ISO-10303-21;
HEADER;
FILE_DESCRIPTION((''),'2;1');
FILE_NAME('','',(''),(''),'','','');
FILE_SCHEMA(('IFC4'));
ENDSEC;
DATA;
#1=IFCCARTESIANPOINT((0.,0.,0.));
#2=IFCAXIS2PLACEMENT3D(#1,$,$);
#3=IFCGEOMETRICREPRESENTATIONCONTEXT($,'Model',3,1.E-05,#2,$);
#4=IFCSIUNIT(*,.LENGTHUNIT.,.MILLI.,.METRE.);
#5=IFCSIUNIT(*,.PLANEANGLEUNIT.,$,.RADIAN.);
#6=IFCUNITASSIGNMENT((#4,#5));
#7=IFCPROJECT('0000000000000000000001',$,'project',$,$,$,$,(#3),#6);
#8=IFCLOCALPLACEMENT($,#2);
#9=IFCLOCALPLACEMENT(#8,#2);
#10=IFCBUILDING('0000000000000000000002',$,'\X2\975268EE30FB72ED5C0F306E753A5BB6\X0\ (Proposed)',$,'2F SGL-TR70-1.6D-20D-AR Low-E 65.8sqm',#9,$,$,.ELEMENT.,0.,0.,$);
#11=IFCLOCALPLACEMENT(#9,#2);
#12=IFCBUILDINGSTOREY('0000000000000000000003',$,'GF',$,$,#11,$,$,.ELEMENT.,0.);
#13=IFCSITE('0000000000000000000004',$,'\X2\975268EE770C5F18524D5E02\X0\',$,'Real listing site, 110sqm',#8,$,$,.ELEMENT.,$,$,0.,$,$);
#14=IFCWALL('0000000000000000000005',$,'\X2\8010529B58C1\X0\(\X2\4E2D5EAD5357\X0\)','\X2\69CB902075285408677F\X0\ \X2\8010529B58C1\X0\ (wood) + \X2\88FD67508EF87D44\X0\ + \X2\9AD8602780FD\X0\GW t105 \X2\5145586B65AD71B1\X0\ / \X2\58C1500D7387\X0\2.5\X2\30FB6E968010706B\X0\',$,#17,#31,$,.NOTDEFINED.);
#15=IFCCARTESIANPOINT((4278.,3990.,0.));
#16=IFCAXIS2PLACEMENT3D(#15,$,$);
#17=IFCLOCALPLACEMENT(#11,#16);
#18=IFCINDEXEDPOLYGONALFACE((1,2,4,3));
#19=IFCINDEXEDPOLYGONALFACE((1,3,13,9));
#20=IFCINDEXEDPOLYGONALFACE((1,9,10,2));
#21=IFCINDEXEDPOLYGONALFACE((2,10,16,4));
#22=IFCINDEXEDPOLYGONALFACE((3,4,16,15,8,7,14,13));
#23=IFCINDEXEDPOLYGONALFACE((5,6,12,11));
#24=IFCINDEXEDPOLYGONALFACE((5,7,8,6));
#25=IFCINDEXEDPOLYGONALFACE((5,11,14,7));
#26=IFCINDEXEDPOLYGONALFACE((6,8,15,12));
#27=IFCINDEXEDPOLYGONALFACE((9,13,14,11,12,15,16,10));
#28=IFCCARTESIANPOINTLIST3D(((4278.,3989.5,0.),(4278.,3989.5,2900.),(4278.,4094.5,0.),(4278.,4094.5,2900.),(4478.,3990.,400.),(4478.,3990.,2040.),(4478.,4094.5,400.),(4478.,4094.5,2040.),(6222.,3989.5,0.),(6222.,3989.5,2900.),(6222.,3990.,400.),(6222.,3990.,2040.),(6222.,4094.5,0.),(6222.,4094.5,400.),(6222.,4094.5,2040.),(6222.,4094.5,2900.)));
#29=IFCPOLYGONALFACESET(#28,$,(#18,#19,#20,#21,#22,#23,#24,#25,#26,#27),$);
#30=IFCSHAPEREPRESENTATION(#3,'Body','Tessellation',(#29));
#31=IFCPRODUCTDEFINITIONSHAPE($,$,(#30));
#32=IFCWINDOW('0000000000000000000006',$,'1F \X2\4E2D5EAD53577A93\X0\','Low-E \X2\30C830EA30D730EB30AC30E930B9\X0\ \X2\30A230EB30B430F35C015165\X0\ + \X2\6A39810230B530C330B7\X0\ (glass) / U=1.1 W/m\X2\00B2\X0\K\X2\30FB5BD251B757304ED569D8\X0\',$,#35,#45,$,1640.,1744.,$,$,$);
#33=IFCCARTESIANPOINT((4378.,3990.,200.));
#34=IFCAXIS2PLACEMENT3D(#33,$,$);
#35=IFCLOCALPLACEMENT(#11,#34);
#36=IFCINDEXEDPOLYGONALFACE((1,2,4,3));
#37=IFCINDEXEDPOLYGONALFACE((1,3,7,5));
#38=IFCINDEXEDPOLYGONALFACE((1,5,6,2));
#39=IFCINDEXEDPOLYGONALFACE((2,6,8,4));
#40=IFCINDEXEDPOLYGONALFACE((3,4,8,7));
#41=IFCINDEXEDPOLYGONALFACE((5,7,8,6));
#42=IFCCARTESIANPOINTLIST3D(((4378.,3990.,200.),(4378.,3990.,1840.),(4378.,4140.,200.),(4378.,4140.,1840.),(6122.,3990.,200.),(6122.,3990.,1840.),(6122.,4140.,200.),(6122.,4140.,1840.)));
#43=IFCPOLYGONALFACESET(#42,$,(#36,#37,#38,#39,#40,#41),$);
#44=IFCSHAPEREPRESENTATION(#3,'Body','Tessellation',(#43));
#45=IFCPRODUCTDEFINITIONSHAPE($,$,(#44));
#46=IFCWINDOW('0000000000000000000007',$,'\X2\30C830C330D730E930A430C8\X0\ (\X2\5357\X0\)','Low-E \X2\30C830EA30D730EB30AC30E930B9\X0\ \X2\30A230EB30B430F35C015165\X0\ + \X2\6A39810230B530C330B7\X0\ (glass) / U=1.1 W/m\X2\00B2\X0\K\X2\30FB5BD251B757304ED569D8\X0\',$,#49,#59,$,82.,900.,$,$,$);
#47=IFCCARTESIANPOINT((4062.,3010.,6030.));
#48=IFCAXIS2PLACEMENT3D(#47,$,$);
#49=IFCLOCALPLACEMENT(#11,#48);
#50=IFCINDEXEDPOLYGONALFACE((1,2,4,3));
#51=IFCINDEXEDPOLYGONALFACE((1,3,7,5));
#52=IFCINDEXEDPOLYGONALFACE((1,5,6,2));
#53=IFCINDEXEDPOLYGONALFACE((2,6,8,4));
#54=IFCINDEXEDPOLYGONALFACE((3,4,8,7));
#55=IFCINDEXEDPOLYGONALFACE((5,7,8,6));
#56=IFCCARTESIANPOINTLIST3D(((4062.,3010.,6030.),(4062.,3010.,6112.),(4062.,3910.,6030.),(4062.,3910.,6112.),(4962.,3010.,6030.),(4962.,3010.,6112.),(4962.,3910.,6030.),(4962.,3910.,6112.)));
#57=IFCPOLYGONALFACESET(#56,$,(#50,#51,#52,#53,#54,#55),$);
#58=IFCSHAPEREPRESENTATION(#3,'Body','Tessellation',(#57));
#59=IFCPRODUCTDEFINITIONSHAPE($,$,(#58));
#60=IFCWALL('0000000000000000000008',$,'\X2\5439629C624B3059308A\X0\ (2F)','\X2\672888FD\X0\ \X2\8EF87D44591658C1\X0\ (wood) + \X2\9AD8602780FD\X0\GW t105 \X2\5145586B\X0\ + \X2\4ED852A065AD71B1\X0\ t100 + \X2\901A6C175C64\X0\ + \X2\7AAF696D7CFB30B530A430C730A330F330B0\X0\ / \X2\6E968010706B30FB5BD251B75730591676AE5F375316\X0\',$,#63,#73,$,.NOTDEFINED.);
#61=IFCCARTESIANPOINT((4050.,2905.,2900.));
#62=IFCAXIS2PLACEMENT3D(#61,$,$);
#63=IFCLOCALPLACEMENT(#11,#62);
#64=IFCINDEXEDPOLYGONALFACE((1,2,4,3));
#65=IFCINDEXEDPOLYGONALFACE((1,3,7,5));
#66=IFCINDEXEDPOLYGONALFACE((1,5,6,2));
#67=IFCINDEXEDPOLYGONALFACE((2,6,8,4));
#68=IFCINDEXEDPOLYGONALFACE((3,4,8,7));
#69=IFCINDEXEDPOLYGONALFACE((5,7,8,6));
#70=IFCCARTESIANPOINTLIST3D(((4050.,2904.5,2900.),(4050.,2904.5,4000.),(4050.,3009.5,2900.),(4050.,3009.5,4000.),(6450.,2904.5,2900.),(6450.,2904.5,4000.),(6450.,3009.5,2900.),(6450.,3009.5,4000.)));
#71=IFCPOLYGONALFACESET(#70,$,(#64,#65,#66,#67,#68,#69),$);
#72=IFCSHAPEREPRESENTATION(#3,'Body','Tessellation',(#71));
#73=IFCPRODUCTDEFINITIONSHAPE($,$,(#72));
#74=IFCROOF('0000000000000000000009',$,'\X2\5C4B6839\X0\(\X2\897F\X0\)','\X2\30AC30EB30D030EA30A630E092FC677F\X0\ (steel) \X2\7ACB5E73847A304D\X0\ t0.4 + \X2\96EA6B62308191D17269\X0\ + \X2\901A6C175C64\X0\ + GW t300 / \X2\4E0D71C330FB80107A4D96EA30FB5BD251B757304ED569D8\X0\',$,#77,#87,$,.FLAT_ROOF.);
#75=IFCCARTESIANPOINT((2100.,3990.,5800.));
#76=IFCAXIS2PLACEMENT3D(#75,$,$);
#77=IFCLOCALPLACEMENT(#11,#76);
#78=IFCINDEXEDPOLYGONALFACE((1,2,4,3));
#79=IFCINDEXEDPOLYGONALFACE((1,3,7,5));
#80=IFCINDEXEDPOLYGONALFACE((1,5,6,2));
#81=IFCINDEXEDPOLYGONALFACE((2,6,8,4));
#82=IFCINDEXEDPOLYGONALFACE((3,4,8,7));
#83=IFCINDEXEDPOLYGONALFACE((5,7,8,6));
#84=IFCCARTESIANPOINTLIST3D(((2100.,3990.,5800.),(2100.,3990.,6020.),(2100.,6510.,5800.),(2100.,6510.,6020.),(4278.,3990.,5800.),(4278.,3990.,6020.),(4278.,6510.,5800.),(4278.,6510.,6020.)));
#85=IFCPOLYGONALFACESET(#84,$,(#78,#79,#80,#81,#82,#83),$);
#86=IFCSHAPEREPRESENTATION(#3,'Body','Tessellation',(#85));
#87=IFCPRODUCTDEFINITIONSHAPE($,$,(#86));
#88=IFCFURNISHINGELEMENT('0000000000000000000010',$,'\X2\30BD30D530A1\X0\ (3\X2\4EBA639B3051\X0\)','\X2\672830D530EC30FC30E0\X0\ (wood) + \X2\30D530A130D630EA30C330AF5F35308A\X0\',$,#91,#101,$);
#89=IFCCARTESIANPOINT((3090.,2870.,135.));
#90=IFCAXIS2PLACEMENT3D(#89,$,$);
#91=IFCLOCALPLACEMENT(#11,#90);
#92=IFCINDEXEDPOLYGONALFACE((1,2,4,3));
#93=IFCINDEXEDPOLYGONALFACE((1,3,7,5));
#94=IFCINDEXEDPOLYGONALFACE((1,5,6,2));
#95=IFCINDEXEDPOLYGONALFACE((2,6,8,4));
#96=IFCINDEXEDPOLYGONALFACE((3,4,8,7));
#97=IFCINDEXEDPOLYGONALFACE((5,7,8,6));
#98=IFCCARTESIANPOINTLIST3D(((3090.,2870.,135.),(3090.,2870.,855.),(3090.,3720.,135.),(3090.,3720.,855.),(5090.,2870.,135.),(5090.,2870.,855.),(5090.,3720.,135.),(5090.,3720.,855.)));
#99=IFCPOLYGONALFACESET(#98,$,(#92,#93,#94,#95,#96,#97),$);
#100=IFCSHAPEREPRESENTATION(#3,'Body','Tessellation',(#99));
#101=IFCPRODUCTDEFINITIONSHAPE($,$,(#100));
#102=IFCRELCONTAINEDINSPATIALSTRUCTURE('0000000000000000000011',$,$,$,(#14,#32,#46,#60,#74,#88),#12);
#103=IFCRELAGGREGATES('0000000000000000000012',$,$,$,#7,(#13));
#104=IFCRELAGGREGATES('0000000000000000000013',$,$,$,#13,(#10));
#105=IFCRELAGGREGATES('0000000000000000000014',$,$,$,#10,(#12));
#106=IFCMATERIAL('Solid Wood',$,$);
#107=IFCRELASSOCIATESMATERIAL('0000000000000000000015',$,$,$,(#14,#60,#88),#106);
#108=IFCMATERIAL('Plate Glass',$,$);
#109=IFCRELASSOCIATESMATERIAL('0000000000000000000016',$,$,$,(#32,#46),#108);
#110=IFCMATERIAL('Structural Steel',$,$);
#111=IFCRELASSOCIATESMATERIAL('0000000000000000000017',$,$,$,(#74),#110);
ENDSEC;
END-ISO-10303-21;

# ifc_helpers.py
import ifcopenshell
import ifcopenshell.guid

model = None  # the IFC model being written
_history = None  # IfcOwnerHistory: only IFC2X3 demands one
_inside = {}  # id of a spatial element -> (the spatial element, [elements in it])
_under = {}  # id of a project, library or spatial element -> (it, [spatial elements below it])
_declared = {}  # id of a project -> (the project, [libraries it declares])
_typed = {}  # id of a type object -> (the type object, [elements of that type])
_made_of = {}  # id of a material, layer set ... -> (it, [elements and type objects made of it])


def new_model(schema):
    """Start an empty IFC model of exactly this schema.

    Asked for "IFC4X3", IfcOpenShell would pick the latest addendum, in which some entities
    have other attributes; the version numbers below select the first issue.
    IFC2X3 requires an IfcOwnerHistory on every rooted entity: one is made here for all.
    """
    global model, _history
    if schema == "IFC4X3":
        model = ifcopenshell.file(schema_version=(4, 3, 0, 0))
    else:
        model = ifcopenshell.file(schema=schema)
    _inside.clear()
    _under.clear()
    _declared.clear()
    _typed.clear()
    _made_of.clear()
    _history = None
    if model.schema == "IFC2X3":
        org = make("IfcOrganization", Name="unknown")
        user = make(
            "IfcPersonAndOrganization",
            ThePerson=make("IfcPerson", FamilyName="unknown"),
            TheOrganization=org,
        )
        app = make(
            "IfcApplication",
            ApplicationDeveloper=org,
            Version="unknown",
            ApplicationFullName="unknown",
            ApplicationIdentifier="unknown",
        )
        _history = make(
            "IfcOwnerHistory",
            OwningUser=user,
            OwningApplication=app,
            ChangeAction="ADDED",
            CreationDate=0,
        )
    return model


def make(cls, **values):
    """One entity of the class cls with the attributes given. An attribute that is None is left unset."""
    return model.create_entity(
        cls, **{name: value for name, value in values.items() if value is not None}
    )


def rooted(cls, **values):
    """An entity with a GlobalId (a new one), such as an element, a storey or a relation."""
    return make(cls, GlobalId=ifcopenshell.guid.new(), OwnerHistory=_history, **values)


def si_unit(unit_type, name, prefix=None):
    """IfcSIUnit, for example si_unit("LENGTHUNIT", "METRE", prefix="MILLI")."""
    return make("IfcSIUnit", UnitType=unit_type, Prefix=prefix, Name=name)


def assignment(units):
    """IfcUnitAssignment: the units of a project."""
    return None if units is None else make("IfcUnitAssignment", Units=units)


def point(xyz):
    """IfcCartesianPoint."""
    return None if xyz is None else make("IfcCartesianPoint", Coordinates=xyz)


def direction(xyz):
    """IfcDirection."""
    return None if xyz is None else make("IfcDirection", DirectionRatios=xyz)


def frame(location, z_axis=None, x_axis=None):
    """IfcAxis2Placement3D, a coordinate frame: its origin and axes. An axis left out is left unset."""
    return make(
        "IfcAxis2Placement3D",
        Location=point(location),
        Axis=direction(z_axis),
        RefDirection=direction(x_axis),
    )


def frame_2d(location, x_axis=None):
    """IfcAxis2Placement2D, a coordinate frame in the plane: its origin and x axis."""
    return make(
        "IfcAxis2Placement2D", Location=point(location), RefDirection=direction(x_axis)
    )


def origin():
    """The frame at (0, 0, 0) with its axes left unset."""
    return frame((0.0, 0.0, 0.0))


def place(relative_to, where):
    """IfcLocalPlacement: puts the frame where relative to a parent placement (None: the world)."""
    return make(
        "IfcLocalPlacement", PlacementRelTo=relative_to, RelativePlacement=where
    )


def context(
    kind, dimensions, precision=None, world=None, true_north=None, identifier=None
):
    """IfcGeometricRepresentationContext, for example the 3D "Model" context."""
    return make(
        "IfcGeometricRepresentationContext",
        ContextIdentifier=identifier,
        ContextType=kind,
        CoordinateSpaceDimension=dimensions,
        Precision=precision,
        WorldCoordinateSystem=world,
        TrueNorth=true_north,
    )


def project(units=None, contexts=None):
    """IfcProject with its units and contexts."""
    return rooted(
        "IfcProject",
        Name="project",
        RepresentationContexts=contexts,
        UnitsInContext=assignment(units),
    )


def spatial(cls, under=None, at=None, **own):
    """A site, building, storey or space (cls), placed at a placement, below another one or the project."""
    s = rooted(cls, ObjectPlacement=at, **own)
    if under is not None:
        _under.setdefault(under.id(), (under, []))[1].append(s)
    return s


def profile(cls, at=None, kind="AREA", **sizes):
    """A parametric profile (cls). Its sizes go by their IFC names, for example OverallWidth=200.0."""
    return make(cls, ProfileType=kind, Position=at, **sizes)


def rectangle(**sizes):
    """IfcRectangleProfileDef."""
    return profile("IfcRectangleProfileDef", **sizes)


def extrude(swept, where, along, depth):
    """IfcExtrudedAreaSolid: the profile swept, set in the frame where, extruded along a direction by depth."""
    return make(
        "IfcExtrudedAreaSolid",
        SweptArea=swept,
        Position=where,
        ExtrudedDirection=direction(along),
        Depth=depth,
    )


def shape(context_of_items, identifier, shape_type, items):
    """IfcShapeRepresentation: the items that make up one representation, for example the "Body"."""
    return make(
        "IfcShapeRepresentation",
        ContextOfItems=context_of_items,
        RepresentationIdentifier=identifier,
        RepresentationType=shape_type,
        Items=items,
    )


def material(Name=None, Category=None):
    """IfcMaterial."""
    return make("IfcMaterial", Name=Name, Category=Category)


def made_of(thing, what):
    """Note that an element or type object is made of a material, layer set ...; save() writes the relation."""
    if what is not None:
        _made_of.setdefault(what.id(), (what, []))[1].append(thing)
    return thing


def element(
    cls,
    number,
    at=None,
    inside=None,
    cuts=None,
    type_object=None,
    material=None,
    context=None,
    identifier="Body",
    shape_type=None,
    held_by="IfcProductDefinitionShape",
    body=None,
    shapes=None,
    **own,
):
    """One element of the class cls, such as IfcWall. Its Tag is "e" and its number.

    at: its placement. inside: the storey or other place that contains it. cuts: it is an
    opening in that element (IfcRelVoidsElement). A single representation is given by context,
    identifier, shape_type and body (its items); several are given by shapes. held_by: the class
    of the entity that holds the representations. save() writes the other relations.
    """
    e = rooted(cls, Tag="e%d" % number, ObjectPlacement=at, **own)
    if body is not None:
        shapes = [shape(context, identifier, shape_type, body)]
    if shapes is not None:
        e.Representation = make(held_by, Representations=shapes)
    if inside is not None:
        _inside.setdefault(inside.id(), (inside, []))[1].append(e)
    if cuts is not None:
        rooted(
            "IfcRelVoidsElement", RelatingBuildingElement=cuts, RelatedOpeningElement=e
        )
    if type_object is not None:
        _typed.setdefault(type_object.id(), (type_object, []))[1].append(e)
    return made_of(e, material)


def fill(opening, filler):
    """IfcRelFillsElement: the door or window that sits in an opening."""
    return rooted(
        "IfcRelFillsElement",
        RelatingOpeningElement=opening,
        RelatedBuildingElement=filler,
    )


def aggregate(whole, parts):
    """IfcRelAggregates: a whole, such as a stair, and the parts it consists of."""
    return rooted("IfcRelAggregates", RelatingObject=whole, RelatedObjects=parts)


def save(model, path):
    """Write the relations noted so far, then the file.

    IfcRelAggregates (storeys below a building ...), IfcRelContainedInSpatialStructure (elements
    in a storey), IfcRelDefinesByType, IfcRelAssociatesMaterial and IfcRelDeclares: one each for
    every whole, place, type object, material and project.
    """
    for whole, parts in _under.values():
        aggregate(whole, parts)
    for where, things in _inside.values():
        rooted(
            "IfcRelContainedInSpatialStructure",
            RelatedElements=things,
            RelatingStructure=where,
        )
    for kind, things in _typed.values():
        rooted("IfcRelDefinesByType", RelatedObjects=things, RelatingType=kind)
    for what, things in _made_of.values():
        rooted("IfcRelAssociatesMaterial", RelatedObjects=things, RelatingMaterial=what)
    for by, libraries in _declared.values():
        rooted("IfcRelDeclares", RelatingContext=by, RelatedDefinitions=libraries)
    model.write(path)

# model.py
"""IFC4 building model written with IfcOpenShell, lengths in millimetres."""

from ifc_helpers import new_model, si_unit, frame, frame_2d, origin, place, context, project, spatial, rectangle, extrude, material, element, fill, save


model = new_model("IFC4")

# Units and contexts
model_context = context("Model", 3, precision=1e-05, world=origin())
ifc_project = project(units=[si_unit("LENGTHUNIT", "METRE", prefix="MILLI"), si_unit("PLANEANGLEUNIT", "RADIAN")], contexts=[model_context])

# Site, building, storey
site_placement = place(None, origin())
site = spatial("IfcSite", under=ifc_project, at=site_placement, Name="青森県弘前市", ObjectType="Real listing site, 110sqm", CompositionType="ELEMENT", RefElevation=0.0)
building_placement = place(site_placement, origin())
building = spatial("IfcBuilding", under=site, at=building_placement, Name="青森・狭小の町家 (Proposed)", ObjectType="2F SGL-TR70-1.6D-20D-AR Low-E 65.8sqm", CompositionType="ELEMENT", ElevationOfRefHeight=0.0, ElevationOfTerrain=0.0)
storey_placement = place(building_placement, origin())
storey = spatial("IfcBuildingStorey", under=building, at=storey_placement, Name="GF", CompositionType="ELEMENT", Elevation=0.0)

# Shared definitions
ifc_material_1 = material(Name="Solid Wood")

# Wall, opening, window
wall_1_placement = place(storey_placement, frame((4278.0, 3990.0, 0.0)))
wall_1 = element("IfcWall", 1, at=wall_1_placement, inside=storey, material=ifc_material_1, Name="耐力壁(中庭南)", Description="構造用合板 耐力壁 (wood) + 製材軸組 + 高性能GW t105 充填断熱 / 壁倍率2.5・準耐火", PredefinedType="NOTDEFINED", context=model_context, shape_type="SweptSolid", body=[
    extrude(rectangle(XDim=1944.0, YDim=105.0, at=frame_2d((972.0, 52.0))), frame((4278.0, 3990.0, 0.0)), (0.0, 0.0, 1.0), 2900.0),
])
opening_placement = place(storey_placement, frame((4378.0, 3990.0, 200.0)))
opening = element("IfcOpeningElement", 2, at=opening_placement, cuts=wall_1, PredefinedType="NOTDEFINED", context=model_context, shape_type="SweptSolid", body=[
    extrude(rectangle(XDim=1744.0, YDim=150.0, at=frame_2d((872.0, 75.0))), frame((4378.0, 3990.0, 200.0)), (0.0, 0.0, 1.0), 1640.0),
])
ifc_material_2 = material(Name="Plate Glass")
window_1_placement = place(storey_placement, frame((4378.0, 3990.0, 200.0)))
window_1 = element("IfcWindow", 3, at=window_1_placement, inside=storey, material=ifc_material_2, Name="1F 中庭南窓", Description="Low-E トリプルガラス アルゴン封入 + 樹脂サッシ (glass) / U=1.1 W/m²K・寒冷地仕様", OverallHeight=1640.0, OverallWidth=1744.0, context=model_context, shape_type="SweptSolid", body=[
    extrude(rectangle(XDim=1744.0, YDim=150.0, at=frame_2d((872.0, 75.0))), frame((4378.0, 3990.0, 200.0)), (0.0, 0.0, 1.0), 1640.0),
])
fill(opening, window_1)

# Window
window_2_placement = place(storey_placement, frame((4062.0, 3010.0, 6030.0)))
element("IfcWindow", 4, at=window_2_placement, inside=storey, material=ifc_material_2, Name="トップライト (南)", Description="Low-E トリプルガラス アルゴン封入 + 樹脂サッシ (glass) / U=1.1 W/m²K・寒冷地仕様", OverallHeight=82.0, OverallWidth=900.0, context=model_context, shape_type="SweptSolid", body=[
    extrude(rectangle(XDim=900.0, YDim=900.0, at=frame_2d((450.0, 450.0))), frame((4062.0, 3010.0, 6030.0)), (0.0, 0.0, 1.0), 82.0),
])

# Wall
wall_2_placement = place(storey_placement, frame((4050.0, 2905.0, 2900.0)))
element("IfcWall", 5, at=wall_2_placement, inside=storey, material=ifc_material_1, Name="吹抜手すり (2F)", Description="木製 軸組外壁 (wood) + 高性能GW t105 充填 + 付加断熱 t100 + 通気層 + 窯業系サイディング / 準耐火・寒冷地外皮強化", PredefinedType="NOTDEFINED", context=model_context, shape_type="SweptSolid", body=[
    extrude(rectangle(XDim=2400.0, YDim=105.0, at=frame_2d((1200.0, 52.0))), frame((4050.0, 2905.0, 2900.0)), (0.0, 0.0, 1.0), 1100.0),
])

# Roof
ifc_material_3 = material(Name="Structural Steel")
for number, where, name in (
    (6, (2100.0, 3990.0, 5800.0), "屋根(西)"),
):
    element("IfcRoof", number, at=place(storey_placement, frame(where)), inside=storey, material=ifc_material_3, Name=name, Description="ガルバリウム鋼板 (steel) 立平葺き t0.4 + 雪止め金物 + 通気層 + GW t300 / 不燃・耐積雪・寒冷地仕様", PredefinedType="FLAT_ROOF", context=model_context, shape_type="SweptSolid", body=[
        extrude(rectangle(XDim=2178.0, YDim=2520.0, at=frame_2d((1089.0, 1260.0))), frame((2100.0, 3990.0, 5800.0)), (0.0, 0.0, 1.0), 220.0),
    ])

# Furnishing element
furnishing_placement = place(storey_placement, frame((3090.0, 2870.0, 135.0)))
element("IfcFurnishingElement", 7, at=furnishing_placement, inside=storey, material=ifc_material_1, Name="ソファ (3人掛け)", Description="木フレーム (wood) + ファブリック張り", context=model_context, shape_type="SweptSolid", body=[
    extrude(rectangle(XDim=2000.0, YDim=850.0, at=frame_2d((1000.0, 425.0))), frame((3090.0, 2870.0, 135.0)), (0.0, 0.0, 1.0), 720.0),
])

save(model, "model.ifc")
